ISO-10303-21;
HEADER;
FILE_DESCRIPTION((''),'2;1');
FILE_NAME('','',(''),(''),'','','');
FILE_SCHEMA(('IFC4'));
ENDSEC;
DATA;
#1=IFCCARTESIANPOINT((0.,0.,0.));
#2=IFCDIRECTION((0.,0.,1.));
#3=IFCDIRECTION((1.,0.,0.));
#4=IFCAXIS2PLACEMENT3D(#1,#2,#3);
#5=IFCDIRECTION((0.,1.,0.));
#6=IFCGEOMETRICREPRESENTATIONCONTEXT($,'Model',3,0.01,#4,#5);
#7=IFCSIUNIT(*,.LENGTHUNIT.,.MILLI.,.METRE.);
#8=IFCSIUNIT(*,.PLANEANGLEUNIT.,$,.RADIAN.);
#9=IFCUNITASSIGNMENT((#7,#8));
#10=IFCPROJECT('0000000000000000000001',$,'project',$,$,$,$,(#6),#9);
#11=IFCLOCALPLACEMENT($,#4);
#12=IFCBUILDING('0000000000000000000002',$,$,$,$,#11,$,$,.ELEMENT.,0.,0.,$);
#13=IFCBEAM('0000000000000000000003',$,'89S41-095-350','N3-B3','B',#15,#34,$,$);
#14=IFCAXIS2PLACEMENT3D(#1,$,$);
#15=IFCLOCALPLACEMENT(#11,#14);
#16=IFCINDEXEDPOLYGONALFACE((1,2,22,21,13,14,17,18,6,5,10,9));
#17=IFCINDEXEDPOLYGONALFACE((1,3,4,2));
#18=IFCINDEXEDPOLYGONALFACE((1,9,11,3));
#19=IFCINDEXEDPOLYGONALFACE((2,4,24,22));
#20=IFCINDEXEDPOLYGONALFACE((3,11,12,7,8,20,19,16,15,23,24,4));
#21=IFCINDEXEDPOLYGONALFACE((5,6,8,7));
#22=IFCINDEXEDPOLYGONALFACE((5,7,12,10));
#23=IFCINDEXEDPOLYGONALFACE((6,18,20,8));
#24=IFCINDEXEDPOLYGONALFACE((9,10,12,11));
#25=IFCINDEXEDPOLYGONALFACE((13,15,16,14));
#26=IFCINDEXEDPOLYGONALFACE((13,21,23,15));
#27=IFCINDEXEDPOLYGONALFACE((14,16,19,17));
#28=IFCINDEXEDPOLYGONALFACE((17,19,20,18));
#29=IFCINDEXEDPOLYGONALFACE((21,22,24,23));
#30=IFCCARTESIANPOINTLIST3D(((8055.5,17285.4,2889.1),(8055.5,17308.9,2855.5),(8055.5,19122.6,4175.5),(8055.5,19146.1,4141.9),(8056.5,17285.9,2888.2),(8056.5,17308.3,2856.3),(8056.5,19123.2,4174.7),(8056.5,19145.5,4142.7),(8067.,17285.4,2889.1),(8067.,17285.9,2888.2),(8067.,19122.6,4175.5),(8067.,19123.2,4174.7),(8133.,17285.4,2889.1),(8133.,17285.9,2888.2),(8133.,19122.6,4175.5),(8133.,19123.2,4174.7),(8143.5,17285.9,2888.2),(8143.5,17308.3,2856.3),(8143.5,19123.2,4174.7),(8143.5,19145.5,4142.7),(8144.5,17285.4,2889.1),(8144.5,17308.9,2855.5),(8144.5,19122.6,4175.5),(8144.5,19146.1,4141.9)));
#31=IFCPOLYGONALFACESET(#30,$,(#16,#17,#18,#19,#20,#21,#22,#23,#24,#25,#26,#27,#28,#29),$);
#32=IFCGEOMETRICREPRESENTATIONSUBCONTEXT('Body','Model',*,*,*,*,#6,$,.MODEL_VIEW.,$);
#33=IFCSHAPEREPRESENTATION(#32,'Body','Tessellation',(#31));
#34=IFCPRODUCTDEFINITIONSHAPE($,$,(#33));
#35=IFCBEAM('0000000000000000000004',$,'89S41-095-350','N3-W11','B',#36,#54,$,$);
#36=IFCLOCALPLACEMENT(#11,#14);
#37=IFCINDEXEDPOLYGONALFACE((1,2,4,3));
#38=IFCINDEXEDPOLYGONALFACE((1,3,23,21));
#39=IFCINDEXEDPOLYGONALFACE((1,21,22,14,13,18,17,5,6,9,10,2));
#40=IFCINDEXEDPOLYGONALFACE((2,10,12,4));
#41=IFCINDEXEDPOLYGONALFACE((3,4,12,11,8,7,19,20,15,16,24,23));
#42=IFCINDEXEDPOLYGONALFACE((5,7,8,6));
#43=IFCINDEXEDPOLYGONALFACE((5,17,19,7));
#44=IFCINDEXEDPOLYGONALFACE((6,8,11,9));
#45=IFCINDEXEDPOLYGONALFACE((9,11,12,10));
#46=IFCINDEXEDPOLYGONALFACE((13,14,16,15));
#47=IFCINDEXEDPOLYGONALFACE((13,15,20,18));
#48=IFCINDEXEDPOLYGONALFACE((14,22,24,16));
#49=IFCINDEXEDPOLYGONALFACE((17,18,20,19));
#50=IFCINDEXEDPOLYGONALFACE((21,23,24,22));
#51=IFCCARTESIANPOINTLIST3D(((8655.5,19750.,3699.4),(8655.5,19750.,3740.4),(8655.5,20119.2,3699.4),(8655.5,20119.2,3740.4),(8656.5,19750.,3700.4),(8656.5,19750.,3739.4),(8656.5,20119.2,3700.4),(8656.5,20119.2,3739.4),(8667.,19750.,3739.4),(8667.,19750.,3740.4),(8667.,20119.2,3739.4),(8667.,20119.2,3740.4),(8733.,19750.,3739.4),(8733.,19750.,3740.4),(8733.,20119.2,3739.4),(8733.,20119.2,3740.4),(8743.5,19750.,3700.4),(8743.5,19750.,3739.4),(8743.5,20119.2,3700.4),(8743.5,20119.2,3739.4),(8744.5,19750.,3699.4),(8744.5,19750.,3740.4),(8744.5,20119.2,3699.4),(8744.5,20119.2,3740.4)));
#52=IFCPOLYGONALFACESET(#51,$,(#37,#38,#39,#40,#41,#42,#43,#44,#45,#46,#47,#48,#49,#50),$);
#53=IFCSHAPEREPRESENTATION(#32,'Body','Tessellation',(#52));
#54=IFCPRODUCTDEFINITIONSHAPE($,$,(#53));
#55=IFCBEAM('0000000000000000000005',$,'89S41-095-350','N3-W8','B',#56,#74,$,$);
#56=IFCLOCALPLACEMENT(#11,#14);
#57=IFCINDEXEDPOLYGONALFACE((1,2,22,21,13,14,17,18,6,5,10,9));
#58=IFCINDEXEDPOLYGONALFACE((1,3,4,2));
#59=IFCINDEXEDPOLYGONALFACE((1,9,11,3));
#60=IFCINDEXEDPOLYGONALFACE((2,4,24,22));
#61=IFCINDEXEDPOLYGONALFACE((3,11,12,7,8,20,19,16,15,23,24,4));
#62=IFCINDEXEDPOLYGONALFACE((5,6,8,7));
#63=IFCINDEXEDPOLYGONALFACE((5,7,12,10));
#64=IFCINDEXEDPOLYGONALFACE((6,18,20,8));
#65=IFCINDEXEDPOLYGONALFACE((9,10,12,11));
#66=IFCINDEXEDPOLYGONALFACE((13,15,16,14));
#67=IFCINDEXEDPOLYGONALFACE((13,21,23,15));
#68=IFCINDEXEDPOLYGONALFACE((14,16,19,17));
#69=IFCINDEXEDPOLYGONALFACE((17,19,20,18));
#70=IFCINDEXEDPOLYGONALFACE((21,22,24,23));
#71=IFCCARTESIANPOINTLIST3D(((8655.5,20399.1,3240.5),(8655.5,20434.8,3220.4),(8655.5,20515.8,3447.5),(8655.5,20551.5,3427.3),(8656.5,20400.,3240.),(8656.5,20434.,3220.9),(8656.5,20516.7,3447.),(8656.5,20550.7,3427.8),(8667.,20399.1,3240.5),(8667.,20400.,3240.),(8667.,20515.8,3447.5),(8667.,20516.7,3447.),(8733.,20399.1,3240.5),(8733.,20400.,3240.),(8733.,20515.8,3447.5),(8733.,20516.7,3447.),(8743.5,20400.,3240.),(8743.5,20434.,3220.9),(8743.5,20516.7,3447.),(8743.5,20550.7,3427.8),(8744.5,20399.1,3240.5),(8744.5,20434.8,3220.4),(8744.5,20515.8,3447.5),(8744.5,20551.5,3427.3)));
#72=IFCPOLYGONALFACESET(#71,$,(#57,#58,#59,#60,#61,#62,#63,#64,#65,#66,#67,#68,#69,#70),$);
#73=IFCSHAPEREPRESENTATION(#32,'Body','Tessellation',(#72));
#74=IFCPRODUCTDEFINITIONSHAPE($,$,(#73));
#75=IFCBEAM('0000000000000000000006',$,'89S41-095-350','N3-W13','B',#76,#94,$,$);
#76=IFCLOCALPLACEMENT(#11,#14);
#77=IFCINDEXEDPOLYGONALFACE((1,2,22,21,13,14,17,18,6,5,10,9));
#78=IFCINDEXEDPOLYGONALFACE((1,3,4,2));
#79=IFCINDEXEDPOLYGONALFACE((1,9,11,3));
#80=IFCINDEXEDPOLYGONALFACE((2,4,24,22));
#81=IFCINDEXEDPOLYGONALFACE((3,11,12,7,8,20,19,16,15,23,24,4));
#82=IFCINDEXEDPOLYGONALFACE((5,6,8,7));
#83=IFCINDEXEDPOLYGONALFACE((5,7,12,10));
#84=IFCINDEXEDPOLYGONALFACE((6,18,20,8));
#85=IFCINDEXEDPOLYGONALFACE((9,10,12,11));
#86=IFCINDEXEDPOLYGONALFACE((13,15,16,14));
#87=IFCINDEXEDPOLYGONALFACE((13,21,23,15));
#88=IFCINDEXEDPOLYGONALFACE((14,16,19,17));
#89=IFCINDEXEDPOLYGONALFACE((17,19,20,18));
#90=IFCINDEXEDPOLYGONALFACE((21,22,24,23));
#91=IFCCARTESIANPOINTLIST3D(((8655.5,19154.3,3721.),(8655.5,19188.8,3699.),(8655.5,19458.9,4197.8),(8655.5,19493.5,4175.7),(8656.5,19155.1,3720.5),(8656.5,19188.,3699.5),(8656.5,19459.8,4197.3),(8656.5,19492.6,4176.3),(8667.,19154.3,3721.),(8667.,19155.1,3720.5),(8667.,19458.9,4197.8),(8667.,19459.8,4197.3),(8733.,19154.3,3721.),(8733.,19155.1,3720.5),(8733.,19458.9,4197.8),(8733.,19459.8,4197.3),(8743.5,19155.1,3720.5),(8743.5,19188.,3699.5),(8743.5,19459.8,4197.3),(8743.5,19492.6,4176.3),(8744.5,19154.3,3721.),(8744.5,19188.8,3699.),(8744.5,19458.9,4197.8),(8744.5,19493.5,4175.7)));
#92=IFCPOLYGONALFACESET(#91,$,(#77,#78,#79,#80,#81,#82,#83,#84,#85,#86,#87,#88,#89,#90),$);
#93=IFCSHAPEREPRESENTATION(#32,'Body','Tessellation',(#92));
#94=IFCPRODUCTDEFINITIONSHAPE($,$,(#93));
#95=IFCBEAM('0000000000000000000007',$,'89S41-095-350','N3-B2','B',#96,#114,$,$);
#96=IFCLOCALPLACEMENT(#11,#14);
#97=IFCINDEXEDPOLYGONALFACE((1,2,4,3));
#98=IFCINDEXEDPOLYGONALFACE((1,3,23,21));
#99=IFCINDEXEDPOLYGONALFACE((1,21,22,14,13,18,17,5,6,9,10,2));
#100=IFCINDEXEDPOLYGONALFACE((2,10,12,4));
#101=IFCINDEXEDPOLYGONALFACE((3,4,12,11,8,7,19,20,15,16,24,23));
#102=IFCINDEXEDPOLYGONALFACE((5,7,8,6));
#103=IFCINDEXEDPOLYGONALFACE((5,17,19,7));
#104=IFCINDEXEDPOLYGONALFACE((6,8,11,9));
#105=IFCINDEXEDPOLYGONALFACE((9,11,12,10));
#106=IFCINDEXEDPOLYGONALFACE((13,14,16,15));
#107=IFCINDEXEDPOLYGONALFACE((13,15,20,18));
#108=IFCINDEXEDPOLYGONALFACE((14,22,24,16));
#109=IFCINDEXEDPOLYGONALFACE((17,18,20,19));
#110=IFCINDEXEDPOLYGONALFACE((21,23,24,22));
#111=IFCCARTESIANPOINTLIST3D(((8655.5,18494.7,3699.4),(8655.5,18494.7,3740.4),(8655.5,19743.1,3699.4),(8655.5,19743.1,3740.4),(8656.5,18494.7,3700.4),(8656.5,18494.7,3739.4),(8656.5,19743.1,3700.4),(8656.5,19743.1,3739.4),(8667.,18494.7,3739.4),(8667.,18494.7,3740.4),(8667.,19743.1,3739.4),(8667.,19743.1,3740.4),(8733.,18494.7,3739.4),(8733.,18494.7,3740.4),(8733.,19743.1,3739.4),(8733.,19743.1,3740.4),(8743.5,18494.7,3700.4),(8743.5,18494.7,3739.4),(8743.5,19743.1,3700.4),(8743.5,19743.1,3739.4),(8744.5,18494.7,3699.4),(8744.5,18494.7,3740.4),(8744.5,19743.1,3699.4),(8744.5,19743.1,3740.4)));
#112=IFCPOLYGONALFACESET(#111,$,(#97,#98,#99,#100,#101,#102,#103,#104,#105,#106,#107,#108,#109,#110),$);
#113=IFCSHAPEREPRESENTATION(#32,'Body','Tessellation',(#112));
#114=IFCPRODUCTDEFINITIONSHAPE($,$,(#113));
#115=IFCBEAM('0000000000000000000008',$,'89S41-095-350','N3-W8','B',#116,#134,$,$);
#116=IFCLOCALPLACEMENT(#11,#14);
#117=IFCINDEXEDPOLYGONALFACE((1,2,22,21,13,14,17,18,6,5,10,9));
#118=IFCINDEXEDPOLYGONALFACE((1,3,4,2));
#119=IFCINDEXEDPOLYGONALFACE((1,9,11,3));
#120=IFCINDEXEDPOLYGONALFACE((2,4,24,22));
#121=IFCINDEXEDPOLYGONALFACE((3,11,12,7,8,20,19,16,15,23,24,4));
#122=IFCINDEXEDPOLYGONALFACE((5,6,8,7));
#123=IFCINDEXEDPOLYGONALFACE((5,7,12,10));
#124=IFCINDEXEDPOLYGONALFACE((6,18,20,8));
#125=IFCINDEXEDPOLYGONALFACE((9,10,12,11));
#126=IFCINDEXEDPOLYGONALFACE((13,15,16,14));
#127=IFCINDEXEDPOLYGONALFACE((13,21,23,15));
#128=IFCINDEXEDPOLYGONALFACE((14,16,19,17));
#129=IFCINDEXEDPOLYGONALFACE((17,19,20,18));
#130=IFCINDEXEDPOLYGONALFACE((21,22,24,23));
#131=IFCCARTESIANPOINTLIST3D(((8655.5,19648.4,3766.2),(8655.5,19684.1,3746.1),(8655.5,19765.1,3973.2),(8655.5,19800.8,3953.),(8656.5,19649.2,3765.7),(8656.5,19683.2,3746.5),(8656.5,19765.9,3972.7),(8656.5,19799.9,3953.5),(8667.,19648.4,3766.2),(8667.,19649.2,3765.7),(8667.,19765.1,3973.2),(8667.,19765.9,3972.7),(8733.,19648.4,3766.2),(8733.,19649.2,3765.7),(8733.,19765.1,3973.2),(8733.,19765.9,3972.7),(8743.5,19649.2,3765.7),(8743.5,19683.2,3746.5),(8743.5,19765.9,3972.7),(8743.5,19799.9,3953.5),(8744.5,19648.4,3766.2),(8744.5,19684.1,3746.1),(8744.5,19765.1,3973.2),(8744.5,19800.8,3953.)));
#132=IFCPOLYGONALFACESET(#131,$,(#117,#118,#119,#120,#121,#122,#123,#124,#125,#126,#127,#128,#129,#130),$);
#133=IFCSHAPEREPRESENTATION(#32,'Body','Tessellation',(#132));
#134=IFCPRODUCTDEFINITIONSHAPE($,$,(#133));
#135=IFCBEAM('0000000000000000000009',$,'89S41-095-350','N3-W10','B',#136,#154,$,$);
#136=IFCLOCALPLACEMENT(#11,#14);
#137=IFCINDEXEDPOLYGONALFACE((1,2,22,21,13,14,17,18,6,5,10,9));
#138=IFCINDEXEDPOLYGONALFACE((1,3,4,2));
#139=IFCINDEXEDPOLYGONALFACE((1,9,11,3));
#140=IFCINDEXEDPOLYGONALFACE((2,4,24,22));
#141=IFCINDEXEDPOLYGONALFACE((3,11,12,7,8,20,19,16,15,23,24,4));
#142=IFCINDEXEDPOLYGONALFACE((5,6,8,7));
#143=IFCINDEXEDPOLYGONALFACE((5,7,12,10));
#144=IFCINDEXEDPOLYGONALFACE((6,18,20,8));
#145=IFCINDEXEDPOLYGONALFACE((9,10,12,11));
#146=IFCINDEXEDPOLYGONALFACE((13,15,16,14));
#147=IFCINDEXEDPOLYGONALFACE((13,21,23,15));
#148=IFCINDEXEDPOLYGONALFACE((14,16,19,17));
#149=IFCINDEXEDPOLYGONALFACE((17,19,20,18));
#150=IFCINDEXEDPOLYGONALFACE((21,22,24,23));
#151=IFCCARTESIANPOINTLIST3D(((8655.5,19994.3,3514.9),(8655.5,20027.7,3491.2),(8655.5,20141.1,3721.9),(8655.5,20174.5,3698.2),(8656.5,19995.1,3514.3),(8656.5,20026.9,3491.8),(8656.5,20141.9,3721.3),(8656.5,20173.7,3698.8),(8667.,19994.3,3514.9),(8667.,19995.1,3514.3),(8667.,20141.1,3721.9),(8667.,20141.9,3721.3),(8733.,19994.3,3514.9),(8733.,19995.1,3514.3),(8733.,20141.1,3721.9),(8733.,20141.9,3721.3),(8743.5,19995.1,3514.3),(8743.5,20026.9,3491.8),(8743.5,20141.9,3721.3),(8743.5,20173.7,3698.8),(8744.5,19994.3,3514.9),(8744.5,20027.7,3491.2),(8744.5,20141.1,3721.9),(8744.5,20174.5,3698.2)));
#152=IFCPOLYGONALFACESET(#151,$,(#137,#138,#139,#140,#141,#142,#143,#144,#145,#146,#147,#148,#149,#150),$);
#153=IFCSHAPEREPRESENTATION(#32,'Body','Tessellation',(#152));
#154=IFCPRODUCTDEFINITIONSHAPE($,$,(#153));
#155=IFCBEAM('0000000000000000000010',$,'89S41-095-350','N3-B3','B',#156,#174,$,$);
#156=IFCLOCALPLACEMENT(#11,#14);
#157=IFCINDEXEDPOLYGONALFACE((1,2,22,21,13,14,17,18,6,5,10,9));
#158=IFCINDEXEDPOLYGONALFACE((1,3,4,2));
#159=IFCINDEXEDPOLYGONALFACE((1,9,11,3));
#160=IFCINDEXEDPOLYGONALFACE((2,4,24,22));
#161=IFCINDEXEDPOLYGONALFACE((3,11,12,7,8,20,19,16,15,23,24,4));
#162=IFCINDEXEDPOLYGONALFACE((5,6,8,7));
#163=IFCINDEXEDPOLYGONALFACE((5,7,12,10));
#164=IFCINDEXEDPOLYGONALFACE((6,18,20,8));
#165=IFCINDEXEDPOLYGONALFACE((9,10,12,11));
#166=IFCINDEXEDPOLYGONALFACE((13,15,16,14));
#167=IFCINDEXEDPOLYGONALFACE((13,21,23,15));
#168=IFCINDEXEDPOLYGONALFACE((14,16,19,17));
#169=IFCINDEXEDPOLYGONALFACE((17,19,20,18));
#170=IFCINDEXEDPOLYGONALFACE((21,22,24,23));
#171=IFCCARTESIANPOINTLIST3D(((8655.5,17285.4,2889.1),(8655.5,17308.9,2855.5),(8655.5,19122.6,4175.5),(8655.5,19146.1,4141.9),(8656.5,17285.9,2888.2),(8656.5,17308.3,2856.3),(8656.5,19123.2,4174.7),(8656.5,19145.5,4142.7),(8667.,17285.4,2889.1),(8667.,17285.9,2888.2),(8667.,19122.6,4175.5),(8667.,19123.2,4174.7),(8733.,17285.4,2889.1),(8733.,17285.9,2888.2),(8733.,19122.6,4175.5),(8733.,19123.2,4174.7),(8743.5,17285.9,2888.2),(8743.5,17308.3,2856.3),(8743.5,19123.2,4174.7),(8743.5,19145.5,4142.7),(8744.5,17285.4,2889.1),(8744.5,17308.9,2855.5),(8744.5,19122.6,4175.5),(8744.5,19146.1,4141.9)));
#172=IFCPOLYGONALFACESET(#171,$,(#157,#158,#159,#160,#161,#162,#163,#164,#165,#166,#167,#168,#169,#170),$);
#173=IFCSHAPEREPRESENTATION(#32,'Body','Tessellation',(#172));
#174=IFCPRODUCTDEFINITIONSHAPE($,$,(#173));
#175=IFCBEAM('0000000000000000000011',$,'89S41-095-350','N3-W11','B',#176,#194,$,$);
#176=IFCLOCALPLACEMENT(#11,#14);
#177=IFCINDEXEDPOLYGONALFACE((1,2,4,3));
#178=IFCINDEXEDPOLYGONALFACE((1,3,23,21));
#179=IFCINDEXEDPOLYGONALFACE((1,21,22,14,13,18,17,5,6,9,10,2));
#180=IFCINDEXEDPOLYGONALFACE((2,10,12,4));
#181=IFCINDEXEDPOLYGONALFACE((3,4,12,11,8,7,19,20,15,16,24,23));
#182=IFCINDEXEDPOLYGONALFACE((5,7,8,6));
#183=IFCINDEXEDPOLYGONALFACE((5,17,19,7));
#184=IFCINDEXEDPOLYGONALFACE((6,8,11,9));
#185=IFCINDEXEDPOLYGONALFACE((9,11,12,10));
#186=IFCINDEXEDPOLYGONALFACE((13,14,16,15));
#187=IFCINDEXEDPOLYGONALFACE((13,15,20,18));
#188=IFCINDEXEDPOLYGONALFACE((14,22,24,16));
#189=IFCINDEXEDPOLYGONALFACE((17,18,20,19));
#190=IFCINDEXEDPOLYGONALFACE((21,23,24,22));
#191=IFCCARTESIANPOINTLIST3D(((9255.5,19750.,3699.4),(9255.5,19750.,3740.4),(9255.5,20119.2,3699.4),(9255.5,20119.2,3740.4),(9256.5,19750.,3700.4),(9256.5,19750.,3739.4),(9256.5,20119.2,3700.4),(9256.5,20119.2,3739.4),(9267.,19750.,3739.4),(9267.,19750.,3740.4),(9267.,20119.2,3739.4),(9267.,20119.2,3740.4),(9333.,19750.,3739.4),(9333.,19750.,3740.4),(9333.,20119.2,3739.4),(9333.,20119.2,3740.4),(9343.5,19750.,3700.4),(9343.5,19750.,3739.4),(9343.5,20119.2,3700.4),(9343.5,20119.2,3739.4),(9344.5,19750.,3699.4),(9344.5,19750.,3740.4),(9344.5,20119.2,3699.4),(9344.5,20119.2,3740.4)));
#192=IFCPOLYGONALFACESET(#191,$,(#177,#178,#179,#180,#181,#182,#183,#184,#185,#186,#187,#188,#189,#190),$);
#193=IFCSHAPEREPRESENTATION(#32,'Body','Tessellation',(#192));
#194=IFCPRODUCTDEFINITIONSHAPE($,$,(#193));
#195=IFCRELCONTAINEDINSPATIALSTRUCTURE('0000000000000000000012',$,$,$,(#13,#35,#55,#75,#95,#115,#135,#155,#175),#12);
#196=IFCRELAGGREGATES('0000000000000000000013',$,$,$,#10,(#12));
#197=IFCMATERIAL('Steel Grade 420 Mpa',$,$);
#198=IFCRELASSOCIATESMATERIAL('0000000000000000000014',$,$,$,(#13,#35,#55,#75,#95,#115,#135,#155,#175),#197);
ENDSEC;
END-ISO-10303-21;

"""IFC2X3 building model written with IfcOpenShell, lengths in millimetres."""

from ifc_helpers import new_model, si_unit, direction, frame, origin, origin_with_axes, origin_2d_with_axis, place, context, subcontext, project, spatial, c_section, extrude, source, transform, mapped, material, element, save


model = new_model("IFC2X3")

# Units and contexts
model_context = context("Model", 3, precision=0.01, world=origin_with_axes(), true_north=direction((0.0, 1.0, 0.0)))
body_context = subcontext(model_context, "Body", "Model", "MODEL_VIEW")
ifc_project = project(units=[si_unit("LENGTHUNIT", "METRE", prefix="MILLI"), si_unit("PLANEANGLEUNIT", "RADIAN")], contexts=[model_context])

# Building
building_placement = place(None, origin_with_axes())
building = spatial("IfcBuilding", under=ifc_project, at=building_placement, CompositionType="ELEMENT", ElevationOfRefHeight=0.0, ElevationOfTerrain=0.0)

# Shared definitions
ifc_material = material(Name="Steel Grade 420 Mpa")

# Beams
shared_shape_1 = source(origin(), body_context, "Body", "SweptSolid", [
    extrude(c_section(Depth=89.0, Width=41.0, WallThickness=1.0, Girth=11.5, at=origin_2d_with_axis()), origin_with_axes(), (0.0, 0.0, 1.0), 2242.8),
])
beam_1_placement = place(None, frame((8100.0, 19134.3, 4158.7), z_axis=(0.0, -0.819152, -0.573576), x_axis=(0.0, -0.573576, 0.819152)))
element("IfcBeam", 1, at=beam_1_placement, inside=building, material=ifc_material, Name="89S41-095-350", Description="N3-B3", ObjectType="B", context=body_context, shape_type="MappedRepresentation", body=[
    mapped(shared_shape_1, transform((0.0, 0.0, 0.0), scale=1.0)),
])
shared_shape_2 = source(origin(), body_context, "Body", "SweptSolid", [
    extrude(c_section(Depth=89.0, Width=41.0, WallThickness=1.0, Girth=11.5, at=origin_2d_with_axis()), origin_with_axes(), (0.0, 0.0, 1.0), 369.2),
])
beam_2_placement = place(None, frame((8700.0, 20119.2, 3719.9), z_axis=(0.0, -1.0, 0.0), x_axis=(0.0, 0.0, 1.0)))
element("IfcBeam", 2, at=beam_2_placement, inside=building, material=ifc_material, Name="89S41-095-350", Description="N3-W11", ObjectType="B", context=body_context, shape_type="MappedRepresentation", body=[
    mapped(shared_shape_2, transform((0.0, 0.0, 0.0), scale=1.0)),
])
shared_shape_3 = source(origin(), body_context, "Body", "SweptSolid", [
    extrude(c_section(Depth=89.0, Width=41.0, WallThickness=1.0, Girth=11.5, at=origin_2d_with_axis()), origin_with_axes(), (0.0, 0.0, 1.0), 237.6),
])
beam_3_placement = place(None, frame((8700.0, 20533.7, 3437.4), z_axis=(0.0, -0.491169, -0.871064), x_axis=(0.0, -0.871064, 0.491169)))
element("IfcBeam", 3, at=beam_3_placement, inside=building, material=ifc_material, Name="89S41-095-350", Description="N3-W8", ObjectType="B", context=body_context, shape_type="MappedRepresentation", body=[
    mapped(shared_shape_3, transform((0.0, 0.0, 0.0), scale=1.0)),
])
shared_shape_4 = source(origin(), body_context, "Body", "SweptSolid", [
    extrude(c_section(Depth=89.0, Width=41.0, WallThickness=1.0, Girth=11.5, at=origin_2d_with_axis()), origin_with_axes(), (0.0, 0.0, 1.0), 565.8),
])
beam_4_placement = place(None, frame((8700.0, 19476.2, 4186.8), z_axis=(0.0, -0.538498, -0.842627), x_axis=(0.0, -0.842627, 0.538498)))
element("IfcBeam", 4, at=beam_4_placement, inside=building, material=ifc_material, Name="89S41-095-350", Description="N3-W13", ObjectType="B", context=body_context, shape_type="MappedRepresentation", body=[
    mapped(shared_shape_4, transform((0.0, 0.0, 0.0), scale=1.0)),
])
shared_shape_5 = source(origin(), body_context, "Body", "SweptSolid", [
    extrude(c_section(Depth=89.0, Width=41.0, WallThickness=1.0, Girth=11.5, at=origin_2d_with_axis()), origin_with_axes(), (0.0, 0.0, 1.0), 1248.4),
])
beam_5_placement = place(None, frame((8700.0, 19743.1, 3719.9), z_axis=(0.0, -1.0, 0.0), x_axis=(0.0, 0.0, 1.0)))
element("IfcBeam", 5, at=beam_5_placement, inside=building, material=ifc_material, Name="89S41-095-350", Description="N3-B2", ObjectType="B", context=body_context, shape_type="MappedRepresentation", body=[
    mapped(shared_shape_5, transform((0.0, 0.0, 0.0), scale=1.0)),
])
shared_shape_6 = source(origin(), body_context, "Body", "SweptSolid", [
    extrude(c_section(Depth=89.0, Width=41.0, WallThickness=1.0, Girth=11.5, at=origin_2d_with_axis()), origin_with_axes(), (0.0, 0.0, 1.0), 237.6),
])
beam_6_placement = place(None, frame((8700.0, 19782.9, 3963.1), z_axis=(0.0, -0.491169, -0.871064), x_axis=(0.0, -0.871064, 0.491169)))
element("IfcBeam", 6, at=beam_6_placement, inside=building, material=ifc_material, Name="89S41-095-350", Description="N3-W8", ObjectType="B", context=body_context, shape_type="MappedRepresentation", body=[
    mapped(shared_shape_6, transform((0.0, 0.0, 0.0), scale=1.0)),
])
shared_shape_7 = source(origin(), body_context, "Body", "SweptSolid", [
    extrude(c_section(Depth=89.0, Width=41.0, WallThickness=1.0, Girth=11.5, at=origin_2d_with_axis()), origin_with_axes(), (0.0, 0.0, 1.0), 253.8),
])
beam_7_placement = place(None, frame((8700.0, 20157.8, 3710.0), z_axis=(0.0, -0.578484, -0.815694), x_axis=(0.0, -0.815694, 0.578484)))
element("IfcBeam", 7, at=beam_7_placement, inside=building, material=ifc_material, Name="89S41-095-350", Description="N3-W10", ObjectType="B", context=body_context, shape_type="MappedRepresentation", body=[
    mapped(shared_shape_7, transform((0.0, 0.0, 0.0), scale=1.0)),
])
shared_shape_8 = source(origin(), body_context, "Body", "SweptSolid", [
    extrude(c_section(Depth=89.0, Width=41.0, WallThickness=1.0, Girth=11.5, at=origin_2d_with_axis()), origin_with_axes(), (0.0, 0.0, 1.0), 2242.8),
])
beam_8_placement = place(None, frame((8700.0, 19134.3, 4158.7), z_axis=(0.0, -0.819152, -0.573576), x_axis=(0.0, -0.573576, 0.819152)))
element("IfcBeam", 8, at=beam_8_placement, inside=building, material=ifc_material, Name="89S41-095-350", Description="N3-B3", ObjectType="B", context=body_context, shape_type="MappedRepresentation", body=[
    mapped(shared_shape_8, transform((0.0, 0.0, 0.0), scale=1.0)),
])
shared_shape_9 = source(origin(), body_context, "Body", "SweptSolid", [
    extrude(c_section(Depth=89.0, Width=41.0, WallThickness=1.0, Girth=11.5, at=origin_2d_with_axis()), origin_with_axes(), (0.0, 0.0, 1.0), 369.2),
])
beam_9_placement = place(None, frame((9300.0, 20119.2, 3719.9), z_axis=(0.0, -1.0, 0.0), x_axis=(0.0, 0.0, 1.0)))
element("IfcBeam", 9, at=beam_9_placement, inside=building, material=ifc_material, Name="89S41-095-350", Description="N3-W11", ObjectType="B", context=body_context, shape_type="MappedRepresentation", body=[
    mapped(shared_shape_9, transform((0.0, 0.0, 0.0), scale=1.0)),
])

save(model, "model.ifc")
